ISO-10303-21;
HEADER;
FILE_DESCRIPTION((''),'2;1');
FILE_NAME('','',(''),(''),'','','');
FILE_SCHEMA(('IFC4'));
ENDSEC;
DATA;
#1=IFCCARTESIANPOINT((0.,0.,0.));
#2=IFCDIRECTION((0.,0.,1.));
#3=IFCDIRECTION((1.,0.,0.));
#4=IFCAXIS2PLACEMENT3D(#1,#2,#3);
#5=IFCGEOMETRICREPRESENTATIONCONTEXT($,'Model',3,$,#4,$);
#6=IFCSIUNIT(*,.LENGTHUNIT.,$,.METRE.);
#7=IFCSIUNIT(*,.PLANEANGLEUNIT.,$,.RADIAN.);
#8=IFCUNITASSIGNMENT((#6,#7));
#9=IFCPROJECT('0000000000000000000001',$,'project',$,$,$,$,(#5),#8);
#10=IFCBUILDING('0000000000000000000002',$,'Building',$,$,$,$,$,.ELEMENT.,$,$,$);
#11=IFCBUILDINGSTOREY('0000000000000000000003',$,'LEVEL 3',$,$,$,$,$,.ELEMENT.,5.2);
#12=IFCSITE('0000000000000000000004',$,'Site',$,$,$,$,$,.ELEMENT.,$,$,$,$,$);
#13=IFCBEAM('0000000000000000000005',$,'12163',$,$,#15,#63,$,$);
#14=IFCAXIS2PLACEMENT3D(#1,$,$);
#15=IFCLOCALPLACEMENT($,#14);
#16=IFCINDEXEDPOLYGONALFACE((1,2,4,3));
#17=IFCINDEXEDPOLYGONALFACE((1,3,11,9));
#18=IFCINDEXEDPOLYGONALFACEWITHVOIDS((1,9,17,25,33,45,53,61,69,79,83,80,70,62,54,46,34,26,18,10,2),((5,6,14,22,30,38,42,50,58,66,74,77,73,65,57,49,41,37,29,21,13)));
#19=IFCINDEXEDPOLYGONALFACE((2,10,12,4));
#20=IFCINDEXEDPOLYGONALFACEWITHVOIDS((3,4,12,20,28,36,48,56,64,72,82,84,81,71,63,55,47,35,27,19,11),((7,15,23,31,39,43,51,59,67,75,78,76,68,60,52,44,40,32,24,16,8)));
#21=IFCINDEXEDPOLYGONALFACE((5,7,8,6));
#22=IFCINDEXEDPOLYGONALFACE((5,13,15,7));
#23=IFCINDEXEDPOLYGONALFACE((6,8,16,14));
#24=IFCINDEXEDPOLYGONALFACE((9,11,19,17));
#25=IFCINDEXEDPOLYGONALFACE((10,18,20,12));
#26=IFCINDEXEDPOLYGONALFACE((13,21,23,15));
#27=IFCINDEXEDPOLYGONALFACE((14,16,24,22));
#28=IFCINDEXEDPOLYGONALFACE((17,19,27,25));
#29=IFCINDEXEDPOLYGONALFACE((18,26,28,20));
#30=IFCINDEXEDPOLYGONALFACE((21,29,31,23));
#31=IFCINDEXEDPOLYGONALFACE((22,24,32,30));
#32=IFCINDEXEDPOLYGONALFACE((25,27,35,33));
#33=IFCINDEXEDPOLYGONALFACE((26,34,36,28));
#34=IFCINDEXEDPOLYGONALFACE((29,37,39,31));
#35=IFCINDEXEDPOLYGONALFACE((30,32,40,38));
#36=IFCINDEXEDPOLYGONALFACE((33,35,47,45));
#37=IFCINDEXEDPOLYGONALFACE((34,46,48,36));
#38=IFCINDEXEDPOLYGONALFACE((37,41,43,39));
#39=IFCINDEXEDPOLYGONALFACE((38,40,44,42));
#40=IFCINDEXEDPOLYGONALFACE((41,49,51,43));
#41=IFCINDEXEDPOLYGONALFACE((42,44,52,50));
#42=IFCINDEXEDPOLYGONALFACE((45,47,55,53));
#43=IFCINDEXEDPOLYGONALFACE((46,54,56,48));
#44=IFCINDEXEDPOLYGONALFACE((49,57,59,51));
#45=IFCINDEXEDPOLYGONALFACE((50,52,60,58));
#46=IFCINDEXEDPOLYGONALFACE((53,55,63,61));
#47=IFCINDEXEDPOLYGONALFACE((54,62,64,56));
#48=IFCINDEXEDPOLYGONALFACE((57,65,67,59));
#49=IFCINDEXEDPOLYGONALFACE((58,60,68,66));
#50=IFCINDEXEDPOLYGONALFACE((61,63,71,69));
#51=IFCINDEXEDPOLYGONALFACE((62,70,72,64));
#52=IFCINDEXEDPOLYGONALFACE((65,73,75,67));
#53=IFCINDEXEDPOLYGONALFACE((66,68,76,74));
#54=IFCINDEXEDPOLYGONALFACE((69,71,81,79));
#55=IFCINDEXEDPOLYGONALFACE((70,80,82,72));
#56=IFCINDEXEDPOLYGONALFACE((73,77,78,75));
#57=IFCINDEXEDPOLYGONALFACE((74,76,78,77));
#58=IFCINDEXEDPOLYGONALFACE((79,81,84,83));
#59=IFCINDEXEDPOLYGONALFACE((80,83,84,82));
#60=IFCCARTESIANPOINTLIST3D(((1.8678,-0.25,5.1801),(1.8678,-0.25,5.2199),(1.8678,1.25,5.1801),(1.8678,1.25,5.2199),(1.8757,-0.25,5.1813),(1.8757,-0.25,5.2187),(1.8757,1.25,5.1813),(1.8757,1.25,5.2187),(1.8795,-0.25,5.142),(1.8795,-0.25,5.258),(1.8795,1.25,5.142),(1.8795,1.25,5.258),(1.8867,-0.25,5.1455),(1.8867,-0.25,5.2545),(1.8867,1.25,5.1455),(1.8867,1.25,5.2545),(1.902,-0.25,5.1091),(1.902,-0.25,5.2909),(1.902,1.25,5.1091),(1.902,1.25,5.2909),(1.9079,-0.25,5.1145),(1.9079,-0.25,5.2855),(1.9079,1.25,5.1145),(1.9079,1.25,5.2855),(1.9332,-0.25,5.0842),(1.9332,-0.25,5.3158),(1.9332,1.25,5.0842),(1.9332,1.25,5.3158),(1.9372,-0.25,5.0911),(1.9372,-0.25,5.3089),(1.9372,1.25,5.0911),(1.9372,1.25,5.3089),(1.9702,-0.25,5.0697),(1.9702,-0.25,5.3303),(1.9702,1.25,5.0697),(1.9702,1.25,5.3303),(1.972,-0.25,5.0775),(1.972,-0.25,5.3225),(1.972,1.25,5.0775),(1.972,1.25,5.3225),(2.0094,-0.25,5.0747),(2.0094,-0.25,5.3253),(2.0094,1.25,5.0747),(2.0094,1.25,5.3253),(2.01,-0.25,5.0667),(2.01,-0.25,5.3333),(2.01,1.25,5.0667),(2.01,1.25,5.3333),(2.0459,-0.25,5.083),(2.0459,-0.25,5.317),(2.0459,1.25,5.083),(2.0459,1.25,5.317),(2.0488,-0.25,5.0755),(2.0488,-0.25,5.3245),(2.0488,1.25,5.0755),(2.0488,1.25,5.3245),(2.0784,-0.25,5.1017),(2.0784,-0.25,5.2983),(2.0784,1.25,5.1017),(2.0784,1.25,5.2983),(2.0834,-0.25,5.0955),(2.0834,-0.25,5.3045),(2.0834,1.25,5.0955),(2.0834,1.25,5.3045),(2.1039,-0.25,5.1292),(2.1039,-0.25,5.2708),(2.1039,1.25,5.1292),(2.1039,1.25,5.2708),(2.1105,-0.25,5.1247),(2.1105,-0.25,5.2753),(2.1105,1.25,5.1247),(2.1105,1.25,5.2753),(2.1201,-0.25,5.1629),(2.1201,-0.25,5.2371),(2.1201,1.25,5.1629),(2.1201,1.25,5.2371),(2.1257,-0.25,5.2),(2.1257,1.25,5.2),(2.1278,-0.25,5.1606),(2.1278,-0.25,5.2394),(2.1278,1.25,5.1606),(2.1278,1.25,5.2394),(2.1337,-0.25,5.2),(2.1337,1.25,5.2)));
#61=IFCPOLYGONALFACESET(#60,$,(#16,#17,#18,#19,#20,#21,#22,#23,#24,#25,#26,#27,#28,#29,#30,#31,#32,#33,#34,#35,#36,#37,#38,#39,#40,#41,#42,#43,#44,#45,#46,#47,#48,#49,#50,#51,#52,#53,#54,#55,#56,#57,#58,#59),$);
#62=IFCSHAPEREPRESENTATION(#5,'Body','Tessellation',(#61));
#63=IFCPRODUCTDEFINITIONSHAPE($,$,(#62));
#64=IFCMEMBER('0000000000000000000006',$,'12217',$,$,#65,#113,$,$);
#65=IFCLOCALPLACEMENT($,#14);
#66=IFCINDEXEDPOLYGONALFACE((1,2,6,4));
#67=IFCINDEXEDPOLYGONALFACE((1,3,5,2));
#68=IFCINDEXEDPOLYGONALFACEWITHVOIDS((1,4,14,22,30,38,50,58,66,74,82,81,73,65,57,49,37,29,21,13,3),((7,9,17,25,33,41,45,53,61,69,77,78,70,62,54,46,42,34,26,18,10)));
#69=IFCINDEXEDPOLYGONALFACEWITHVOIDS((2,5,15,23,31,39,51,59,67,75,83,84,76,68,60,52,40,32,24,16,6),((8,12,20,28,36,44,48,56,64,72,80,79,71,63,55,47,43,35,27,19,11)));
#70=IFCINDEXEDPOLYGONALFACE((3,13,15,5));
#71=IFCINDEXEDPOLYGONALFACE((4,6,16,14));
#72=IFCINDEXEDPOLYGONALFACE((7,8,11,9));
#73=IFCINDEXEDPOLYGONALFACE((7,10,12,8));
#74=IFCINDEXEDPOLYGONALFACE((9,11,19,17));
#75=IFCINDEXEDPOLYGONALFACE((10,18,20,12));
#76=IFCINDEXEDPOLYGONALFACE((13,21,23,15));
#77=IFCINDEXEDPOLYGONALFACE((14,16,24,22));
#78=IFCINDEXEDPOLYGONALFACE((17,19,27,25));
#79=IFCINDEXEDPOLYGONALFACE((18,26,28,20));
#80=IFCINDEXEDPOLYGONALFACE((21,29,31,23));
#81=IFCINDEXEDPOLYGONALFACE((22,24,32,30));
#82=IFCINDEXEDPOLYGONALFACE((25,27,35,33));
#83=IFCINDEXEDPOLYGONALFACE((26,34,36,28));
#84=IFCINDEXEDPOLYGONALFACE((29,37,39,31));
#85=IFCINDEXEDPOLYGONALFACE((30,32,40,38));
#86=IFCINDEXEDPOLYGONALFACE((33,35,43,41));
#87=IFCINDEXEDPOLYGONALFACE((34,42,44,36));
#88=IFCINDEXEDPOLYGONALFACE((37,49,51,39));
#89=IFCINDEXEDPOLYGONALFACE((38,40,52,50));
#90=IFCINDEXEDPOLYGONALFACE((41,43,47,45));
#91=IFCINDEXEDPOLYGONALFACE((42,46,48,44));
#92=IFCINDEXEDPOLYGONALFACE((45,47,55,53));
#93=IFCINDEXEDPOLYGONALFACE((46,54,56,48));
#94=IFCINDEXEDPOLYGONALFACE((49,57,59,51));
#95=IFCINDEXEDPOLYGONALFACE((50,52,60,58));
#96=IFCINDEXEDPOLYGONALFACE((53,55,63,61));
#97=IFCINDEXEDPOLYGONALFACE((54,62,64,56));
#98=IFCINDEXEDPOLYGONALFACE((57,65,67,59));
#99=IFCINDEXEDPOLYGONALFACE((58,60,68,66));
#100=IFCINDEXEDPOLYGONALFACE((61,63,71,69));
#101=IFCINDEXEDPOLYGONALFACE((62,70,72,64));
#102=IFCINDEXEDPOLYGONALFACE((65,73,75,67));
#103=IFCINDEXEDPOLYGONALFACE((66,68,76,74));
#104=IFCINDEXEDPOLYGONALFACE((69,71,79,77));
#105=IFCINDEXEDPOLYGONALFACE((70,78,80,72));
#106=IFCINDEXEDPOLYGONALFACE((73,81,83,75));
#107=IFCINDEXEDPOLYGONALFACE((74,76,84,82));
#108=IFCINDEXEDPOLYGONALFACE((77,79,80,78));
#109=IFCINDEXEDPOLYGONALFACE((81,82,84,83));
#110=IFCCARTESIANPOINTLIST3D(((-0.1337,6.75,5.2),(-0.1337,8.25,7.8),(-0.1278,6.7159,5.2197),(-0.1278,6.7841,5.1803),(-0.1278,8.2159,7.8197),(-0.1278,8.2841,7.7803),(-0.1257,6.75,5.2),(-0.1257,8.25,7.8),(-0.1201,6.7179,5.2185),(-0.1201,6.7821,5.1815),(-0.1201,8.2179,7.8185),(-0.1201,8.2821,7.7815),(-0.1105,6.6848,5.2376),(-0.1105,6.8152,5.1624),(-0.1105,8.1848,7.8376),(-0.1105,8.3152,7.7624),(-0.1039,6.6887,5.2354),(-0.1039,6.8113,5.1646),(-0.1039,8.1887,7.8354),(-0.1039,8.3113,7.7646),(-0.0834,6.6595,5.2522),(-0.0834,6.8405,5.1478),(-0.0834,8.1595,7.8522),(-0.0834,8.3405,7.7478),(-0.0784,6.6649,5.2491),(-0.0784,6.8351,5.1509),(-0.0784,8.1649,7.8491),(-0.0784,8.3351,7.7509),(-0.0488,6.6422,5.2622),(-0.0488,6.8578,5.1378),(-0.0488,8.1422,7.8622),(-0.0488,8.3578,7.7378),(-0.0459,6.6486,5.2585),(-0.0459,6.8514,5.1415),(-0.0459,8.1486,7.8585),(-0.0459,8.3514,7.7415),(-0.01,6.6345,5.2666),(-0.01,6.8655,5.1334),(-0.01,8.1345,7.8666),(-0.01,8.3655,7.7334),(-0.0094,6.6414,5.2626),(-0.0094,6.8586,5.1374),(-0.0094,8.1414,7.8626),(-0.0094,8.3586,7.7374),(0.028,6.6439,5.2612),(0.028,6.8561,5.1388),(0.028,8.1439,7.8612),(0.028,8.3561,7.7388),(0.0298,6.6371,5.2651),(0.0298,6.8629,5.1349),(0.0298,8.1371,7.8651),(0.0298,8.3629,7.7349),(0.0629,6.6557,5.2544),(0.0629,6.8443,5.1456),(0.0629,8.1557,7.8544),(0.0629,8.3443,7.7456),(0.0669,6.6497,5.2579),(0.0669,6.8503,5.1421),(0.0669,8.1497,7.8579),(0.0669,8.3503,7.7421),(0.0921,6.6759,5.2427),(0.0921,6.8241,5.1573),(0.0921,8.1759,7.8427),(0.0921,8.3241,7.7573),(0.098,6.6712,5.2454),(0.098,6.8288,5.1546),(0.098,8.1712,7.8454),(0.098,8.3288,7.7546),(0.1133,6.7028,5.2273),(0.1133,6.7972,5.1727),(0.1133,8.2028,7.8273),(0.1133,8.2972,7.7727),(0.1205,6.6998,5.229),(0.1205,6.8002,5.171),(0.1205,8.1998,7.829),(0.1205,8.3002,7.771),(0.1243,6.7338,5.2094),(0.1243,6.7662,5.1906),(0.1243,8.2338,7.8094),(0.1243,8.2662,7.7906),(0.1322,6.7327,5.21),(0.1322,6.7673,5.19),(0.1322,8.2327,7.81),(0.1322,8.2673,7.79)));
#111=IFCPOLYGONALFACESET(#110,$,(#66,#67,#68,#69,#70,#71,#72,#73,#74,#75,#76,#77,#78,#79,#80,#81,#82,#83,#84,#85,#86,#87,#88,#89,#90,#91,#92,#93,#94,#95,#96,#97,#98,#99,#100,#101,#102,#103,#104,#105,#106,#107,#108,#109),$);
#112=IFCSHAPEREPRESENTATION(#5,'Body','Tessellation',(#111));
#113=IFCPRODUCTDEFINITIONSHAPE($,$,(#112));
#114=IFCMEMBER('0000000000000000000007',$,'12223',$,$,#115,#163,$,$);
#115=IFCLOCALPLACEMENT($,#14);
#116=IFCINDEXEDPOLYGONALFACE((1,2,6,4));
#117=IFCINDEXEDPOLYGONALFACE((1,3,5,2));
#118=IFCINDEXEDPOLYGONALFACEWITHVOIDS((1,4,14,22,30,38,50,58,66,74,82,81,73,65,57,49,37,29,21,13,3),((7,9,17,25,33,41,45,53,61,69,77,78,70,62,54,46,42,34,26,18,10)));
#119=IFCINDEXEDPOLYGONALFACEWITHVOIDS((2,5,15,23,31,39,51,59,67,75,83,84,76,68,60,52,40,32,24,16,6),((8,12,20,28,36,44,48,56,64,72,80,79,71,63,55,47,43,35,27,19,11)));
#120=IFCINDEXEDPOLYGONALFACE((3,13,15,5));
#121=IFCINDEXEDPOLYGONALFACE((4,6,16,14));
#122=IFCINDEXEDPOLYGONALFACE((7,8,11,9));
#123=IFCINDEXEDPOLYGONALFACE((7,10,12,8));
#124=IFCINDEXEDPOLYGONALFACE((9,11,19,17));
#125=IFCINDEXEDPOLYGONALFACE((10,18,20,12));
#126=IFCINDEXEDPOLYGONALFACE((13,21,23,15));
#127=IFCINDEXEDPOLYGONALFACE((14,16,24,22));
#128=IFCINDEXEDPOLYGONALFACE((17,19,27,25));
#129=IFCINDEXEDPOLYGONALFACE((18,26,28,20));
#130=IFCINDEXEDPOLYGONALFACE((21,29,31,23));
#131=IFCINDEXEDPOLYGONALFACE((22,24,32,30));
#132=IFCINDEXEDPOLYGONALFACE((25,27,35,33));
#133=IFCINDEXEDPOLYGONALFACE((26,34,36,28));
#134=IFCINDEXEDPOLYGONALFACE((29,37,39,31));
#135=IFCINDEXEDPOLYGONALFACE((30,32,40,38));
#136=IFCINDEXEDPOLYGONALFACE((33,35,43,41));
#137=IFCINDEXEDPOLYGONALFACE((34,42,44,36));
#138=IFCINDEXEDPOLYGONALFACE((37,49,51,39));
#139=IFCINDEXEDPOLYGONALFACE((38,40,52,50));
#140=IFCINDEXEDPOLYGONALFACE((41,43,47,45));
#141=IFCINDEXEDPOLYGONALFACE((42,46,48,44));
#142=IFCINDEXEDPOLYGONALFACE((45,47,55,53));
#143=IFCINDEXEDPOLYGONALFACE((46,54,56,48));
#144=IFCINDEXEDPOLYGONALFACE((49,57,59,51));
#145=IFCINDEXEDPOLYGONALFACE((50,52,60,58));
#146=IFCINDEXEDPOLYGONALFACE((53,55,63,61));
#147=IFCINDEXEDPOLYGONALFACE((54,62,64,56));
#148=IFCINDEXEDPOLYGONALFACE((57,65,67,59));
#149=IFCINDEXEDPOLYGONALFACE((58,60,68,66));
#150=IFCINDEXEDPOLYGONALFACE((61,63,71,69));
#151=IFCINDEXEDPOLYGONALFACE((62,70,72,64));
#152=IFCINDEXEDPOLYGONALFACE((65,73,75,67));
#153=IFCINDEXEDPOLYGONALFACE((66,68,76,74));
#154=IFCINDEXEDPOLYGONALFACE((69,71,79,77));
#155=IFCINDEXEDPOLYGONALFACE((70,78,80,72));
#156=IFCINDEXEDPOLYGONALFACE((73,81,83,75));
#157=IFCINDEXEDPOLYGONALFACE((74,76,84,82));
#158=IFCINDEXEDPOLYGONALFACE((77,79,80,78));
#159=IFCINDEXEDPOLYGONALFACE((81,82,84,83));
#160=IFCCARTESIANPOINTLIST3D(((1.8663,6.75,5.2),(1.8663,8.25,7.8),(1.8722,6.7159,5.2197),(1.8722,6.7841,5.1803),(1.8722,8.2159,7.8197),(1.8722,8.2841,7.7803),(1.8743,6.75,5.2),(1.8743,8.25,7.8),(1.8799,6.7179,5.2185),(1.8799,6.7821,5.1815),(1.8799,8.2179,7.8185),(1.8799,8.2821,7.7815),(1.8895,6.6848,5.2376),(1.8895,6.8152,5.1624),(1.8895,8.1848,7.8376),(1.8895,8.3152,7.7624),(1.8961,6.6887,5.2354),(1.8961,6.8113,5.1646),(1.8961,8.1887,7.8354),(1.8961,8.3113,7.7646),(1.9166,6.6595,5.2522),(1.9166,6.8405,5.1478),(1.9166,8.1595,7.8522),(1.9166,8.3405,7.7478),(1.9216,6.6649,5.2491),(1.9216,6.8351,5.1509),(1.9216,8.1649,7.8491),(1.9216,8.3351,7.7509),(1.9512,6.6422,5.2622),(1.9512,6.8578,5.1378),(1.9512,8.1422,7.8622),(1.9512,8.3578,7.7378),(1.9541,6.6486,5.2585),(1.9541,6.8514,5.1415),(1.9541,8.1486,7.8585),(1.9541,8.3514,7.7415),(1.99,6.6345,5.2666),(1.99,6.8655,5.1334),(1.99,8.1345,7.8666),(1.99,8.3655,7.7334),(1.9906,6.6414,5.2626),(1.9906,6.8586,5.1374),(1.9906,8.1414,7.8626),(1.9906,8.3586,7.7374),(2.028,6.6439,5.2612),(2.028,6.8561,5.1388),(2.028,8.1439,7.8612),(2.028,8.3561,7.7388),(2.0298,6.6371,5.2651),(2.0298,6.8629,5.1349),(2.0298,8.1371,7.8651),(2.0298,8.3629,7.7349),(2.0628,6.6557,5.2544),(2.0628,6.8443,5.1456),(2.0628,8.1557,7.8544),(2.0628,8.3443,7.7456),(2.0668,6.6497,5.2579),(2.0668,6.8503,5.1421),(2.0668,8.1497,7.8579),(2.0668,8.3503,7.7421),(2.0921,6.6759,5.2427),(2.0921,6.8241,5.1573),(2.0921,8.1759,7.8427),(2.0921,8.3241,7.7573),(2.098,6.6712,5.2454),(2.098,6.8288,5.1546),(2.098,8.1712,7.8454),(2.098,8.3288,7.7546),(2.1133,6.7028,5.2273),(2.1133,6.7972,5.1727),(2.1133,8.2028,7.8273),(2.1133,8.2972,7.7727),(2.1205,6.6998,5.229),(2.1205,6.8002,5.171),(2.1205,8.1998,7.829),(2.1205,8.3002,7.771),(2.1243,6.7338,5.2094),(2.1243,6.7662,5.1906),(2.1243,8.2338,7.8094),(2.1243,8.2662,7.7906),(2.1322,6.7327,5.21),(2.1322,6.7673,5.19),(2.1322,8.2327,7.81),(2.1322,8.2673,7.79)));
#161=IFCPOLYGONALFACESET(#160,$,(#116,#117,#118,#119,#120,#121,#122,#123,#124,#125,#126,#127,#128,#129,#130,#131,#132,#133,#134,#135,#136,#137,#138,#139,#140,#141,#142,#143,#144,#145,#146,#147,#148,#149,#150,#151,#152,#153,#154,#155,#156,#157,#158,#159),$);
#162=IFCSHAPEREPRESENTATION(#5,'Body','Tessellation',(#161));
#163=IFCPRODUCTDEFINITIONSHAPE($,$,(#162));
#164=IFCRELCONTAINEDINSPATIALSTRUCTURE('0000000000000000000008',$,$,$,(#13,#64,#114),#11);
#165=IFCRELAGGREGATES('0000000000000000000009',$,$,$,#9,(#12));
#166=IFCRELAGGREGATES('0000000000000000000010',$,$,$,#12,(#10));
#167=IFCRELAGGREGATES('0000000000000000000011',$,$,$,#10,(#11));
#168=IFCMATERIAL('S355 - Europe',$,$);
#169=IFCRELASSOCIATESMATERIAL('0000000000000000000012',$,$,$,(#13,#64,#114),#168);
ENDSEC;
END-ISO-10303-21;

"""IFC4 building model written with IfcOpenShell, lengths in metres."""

from ifc_helpers import new_model, si_unit, frame, origin_with_axes, origin_2d_with_axis, place, context, project, spatial, hollow_circle, extrude, material, material_profile, profile_set, profile_usage, element, save


model = new_model("IFC4")

# Units and contexts
model_context = context("Model", 3, world=origin_with_axes())
ifc_project = project(units=[si_unit("LENGTHUNIT", "METRE"), si_unit("PLANEANGLEUNIT", "RADIAN")], contexts=[model_context])

# Site, building, storey
site = spatial("IfcSite", under=ifc_project, Name="Site", CompositionType="ELEMENT")
building = spatial("IfcBuilding", under=site, Name="Building", CompositionType="ELEMENT")
storey = spatial("IfcBuildingStorey", under=building, Name="LEVEL 3", CompositionType="ELEMENT", Elevation=5.2)

# Shared definitions
ifc_material = material(Name="S355 - Europe")

# Beam
ifc_material_profile_1 = material_profile(ifc_material, hollow_circle(Radius=0.1337, WallThickness=0.008, at=origin_2d_with_axis()))
ifc_profile_set_1 = profile_set([ifc_material_profile_1])
ifc_profile_usage_1 = profile_usage(ifc_profile_set_1, cardinal=10)
beam_1_placement = place(None, frame((2.0, 1.25, 5.2), z_axis=(0.0, -1.0, 0.0), x_axis=(1.0, 0.0, 0.0)))
element("IfcBeam", 1, at=beam_1_placement, inside=storey, material=ifc_profile_usage_1, Name="12163", context=model_context, shape_type="SweptSolid", body=[
    extrude(hollow_circle(Radius=0.1337, WallThickness=0.008, at=origin_2d_with_axis()), origin_with_axes(), (0.0, 0.0, 1.0), 1.5),
])

# Members
ifc_material_profile_2 = material_profile(ifc_material, hollow_circle(Radius=0.1337, WallThickness=0.008, at=origin_2d_with_axis()))
ifc_profile_set_2 = profile_set([ifc_material_profile_2])
ifc_profile_usage_2 = profile_usage(ifc_profile_set_2, cardinal=10)
member_1_placement = place(None, frame((0.0, 6.75, 5.2), z_axis=(0.0, 0.499722, 0.866186), x_axis=(-1.0, 0.0, 0.0)))
element("IfcMember", 2, at=member_1_placement, inside=storey, material=ifc_profile_usage_2, Name="12217", context=model_context, shape_type="SweptSolid", body=[
    extrude(hollow_circle(Radius=0.1337, WallThickness=0.008, at=origin_2d_with_axis()), origin_with_axes(), (0.0, 0.0, 1.0), 3.0017),
])
ifc_material_profile_3 = material_profile(ifc_material, hollow_circle(Radius=0.1337, WallThickness=0.008, at=origin_2d_with_axis()))
ifc_profile_set_3 = profile_set([ifc_material_profile_3])
ifc_profile_usage_3 = profile_usage(ifc_profile_set_3, cardinal=10)
member_2_placement = place(None, frame((2.0, 6.75, 5.2), z_axis=(0.0, 0.499722, 0.866186), x_axis=(-1.0, 0.0, 0.0)))
element("IfcMember", 3, at=member_2_placement, inside=storey, material=ifc_profile_usage_3, Name="12223", context=model_context, shape_type="SweptSolid", body=[
    extrude(hollow_circle(Radius=0.1337, WallThickness=0.008, at=origin_2d_with_axis()), origin_with_axes(), (0.0, 0.0, 1.0), 3.0017),
])

save(model, "model.ifc")
